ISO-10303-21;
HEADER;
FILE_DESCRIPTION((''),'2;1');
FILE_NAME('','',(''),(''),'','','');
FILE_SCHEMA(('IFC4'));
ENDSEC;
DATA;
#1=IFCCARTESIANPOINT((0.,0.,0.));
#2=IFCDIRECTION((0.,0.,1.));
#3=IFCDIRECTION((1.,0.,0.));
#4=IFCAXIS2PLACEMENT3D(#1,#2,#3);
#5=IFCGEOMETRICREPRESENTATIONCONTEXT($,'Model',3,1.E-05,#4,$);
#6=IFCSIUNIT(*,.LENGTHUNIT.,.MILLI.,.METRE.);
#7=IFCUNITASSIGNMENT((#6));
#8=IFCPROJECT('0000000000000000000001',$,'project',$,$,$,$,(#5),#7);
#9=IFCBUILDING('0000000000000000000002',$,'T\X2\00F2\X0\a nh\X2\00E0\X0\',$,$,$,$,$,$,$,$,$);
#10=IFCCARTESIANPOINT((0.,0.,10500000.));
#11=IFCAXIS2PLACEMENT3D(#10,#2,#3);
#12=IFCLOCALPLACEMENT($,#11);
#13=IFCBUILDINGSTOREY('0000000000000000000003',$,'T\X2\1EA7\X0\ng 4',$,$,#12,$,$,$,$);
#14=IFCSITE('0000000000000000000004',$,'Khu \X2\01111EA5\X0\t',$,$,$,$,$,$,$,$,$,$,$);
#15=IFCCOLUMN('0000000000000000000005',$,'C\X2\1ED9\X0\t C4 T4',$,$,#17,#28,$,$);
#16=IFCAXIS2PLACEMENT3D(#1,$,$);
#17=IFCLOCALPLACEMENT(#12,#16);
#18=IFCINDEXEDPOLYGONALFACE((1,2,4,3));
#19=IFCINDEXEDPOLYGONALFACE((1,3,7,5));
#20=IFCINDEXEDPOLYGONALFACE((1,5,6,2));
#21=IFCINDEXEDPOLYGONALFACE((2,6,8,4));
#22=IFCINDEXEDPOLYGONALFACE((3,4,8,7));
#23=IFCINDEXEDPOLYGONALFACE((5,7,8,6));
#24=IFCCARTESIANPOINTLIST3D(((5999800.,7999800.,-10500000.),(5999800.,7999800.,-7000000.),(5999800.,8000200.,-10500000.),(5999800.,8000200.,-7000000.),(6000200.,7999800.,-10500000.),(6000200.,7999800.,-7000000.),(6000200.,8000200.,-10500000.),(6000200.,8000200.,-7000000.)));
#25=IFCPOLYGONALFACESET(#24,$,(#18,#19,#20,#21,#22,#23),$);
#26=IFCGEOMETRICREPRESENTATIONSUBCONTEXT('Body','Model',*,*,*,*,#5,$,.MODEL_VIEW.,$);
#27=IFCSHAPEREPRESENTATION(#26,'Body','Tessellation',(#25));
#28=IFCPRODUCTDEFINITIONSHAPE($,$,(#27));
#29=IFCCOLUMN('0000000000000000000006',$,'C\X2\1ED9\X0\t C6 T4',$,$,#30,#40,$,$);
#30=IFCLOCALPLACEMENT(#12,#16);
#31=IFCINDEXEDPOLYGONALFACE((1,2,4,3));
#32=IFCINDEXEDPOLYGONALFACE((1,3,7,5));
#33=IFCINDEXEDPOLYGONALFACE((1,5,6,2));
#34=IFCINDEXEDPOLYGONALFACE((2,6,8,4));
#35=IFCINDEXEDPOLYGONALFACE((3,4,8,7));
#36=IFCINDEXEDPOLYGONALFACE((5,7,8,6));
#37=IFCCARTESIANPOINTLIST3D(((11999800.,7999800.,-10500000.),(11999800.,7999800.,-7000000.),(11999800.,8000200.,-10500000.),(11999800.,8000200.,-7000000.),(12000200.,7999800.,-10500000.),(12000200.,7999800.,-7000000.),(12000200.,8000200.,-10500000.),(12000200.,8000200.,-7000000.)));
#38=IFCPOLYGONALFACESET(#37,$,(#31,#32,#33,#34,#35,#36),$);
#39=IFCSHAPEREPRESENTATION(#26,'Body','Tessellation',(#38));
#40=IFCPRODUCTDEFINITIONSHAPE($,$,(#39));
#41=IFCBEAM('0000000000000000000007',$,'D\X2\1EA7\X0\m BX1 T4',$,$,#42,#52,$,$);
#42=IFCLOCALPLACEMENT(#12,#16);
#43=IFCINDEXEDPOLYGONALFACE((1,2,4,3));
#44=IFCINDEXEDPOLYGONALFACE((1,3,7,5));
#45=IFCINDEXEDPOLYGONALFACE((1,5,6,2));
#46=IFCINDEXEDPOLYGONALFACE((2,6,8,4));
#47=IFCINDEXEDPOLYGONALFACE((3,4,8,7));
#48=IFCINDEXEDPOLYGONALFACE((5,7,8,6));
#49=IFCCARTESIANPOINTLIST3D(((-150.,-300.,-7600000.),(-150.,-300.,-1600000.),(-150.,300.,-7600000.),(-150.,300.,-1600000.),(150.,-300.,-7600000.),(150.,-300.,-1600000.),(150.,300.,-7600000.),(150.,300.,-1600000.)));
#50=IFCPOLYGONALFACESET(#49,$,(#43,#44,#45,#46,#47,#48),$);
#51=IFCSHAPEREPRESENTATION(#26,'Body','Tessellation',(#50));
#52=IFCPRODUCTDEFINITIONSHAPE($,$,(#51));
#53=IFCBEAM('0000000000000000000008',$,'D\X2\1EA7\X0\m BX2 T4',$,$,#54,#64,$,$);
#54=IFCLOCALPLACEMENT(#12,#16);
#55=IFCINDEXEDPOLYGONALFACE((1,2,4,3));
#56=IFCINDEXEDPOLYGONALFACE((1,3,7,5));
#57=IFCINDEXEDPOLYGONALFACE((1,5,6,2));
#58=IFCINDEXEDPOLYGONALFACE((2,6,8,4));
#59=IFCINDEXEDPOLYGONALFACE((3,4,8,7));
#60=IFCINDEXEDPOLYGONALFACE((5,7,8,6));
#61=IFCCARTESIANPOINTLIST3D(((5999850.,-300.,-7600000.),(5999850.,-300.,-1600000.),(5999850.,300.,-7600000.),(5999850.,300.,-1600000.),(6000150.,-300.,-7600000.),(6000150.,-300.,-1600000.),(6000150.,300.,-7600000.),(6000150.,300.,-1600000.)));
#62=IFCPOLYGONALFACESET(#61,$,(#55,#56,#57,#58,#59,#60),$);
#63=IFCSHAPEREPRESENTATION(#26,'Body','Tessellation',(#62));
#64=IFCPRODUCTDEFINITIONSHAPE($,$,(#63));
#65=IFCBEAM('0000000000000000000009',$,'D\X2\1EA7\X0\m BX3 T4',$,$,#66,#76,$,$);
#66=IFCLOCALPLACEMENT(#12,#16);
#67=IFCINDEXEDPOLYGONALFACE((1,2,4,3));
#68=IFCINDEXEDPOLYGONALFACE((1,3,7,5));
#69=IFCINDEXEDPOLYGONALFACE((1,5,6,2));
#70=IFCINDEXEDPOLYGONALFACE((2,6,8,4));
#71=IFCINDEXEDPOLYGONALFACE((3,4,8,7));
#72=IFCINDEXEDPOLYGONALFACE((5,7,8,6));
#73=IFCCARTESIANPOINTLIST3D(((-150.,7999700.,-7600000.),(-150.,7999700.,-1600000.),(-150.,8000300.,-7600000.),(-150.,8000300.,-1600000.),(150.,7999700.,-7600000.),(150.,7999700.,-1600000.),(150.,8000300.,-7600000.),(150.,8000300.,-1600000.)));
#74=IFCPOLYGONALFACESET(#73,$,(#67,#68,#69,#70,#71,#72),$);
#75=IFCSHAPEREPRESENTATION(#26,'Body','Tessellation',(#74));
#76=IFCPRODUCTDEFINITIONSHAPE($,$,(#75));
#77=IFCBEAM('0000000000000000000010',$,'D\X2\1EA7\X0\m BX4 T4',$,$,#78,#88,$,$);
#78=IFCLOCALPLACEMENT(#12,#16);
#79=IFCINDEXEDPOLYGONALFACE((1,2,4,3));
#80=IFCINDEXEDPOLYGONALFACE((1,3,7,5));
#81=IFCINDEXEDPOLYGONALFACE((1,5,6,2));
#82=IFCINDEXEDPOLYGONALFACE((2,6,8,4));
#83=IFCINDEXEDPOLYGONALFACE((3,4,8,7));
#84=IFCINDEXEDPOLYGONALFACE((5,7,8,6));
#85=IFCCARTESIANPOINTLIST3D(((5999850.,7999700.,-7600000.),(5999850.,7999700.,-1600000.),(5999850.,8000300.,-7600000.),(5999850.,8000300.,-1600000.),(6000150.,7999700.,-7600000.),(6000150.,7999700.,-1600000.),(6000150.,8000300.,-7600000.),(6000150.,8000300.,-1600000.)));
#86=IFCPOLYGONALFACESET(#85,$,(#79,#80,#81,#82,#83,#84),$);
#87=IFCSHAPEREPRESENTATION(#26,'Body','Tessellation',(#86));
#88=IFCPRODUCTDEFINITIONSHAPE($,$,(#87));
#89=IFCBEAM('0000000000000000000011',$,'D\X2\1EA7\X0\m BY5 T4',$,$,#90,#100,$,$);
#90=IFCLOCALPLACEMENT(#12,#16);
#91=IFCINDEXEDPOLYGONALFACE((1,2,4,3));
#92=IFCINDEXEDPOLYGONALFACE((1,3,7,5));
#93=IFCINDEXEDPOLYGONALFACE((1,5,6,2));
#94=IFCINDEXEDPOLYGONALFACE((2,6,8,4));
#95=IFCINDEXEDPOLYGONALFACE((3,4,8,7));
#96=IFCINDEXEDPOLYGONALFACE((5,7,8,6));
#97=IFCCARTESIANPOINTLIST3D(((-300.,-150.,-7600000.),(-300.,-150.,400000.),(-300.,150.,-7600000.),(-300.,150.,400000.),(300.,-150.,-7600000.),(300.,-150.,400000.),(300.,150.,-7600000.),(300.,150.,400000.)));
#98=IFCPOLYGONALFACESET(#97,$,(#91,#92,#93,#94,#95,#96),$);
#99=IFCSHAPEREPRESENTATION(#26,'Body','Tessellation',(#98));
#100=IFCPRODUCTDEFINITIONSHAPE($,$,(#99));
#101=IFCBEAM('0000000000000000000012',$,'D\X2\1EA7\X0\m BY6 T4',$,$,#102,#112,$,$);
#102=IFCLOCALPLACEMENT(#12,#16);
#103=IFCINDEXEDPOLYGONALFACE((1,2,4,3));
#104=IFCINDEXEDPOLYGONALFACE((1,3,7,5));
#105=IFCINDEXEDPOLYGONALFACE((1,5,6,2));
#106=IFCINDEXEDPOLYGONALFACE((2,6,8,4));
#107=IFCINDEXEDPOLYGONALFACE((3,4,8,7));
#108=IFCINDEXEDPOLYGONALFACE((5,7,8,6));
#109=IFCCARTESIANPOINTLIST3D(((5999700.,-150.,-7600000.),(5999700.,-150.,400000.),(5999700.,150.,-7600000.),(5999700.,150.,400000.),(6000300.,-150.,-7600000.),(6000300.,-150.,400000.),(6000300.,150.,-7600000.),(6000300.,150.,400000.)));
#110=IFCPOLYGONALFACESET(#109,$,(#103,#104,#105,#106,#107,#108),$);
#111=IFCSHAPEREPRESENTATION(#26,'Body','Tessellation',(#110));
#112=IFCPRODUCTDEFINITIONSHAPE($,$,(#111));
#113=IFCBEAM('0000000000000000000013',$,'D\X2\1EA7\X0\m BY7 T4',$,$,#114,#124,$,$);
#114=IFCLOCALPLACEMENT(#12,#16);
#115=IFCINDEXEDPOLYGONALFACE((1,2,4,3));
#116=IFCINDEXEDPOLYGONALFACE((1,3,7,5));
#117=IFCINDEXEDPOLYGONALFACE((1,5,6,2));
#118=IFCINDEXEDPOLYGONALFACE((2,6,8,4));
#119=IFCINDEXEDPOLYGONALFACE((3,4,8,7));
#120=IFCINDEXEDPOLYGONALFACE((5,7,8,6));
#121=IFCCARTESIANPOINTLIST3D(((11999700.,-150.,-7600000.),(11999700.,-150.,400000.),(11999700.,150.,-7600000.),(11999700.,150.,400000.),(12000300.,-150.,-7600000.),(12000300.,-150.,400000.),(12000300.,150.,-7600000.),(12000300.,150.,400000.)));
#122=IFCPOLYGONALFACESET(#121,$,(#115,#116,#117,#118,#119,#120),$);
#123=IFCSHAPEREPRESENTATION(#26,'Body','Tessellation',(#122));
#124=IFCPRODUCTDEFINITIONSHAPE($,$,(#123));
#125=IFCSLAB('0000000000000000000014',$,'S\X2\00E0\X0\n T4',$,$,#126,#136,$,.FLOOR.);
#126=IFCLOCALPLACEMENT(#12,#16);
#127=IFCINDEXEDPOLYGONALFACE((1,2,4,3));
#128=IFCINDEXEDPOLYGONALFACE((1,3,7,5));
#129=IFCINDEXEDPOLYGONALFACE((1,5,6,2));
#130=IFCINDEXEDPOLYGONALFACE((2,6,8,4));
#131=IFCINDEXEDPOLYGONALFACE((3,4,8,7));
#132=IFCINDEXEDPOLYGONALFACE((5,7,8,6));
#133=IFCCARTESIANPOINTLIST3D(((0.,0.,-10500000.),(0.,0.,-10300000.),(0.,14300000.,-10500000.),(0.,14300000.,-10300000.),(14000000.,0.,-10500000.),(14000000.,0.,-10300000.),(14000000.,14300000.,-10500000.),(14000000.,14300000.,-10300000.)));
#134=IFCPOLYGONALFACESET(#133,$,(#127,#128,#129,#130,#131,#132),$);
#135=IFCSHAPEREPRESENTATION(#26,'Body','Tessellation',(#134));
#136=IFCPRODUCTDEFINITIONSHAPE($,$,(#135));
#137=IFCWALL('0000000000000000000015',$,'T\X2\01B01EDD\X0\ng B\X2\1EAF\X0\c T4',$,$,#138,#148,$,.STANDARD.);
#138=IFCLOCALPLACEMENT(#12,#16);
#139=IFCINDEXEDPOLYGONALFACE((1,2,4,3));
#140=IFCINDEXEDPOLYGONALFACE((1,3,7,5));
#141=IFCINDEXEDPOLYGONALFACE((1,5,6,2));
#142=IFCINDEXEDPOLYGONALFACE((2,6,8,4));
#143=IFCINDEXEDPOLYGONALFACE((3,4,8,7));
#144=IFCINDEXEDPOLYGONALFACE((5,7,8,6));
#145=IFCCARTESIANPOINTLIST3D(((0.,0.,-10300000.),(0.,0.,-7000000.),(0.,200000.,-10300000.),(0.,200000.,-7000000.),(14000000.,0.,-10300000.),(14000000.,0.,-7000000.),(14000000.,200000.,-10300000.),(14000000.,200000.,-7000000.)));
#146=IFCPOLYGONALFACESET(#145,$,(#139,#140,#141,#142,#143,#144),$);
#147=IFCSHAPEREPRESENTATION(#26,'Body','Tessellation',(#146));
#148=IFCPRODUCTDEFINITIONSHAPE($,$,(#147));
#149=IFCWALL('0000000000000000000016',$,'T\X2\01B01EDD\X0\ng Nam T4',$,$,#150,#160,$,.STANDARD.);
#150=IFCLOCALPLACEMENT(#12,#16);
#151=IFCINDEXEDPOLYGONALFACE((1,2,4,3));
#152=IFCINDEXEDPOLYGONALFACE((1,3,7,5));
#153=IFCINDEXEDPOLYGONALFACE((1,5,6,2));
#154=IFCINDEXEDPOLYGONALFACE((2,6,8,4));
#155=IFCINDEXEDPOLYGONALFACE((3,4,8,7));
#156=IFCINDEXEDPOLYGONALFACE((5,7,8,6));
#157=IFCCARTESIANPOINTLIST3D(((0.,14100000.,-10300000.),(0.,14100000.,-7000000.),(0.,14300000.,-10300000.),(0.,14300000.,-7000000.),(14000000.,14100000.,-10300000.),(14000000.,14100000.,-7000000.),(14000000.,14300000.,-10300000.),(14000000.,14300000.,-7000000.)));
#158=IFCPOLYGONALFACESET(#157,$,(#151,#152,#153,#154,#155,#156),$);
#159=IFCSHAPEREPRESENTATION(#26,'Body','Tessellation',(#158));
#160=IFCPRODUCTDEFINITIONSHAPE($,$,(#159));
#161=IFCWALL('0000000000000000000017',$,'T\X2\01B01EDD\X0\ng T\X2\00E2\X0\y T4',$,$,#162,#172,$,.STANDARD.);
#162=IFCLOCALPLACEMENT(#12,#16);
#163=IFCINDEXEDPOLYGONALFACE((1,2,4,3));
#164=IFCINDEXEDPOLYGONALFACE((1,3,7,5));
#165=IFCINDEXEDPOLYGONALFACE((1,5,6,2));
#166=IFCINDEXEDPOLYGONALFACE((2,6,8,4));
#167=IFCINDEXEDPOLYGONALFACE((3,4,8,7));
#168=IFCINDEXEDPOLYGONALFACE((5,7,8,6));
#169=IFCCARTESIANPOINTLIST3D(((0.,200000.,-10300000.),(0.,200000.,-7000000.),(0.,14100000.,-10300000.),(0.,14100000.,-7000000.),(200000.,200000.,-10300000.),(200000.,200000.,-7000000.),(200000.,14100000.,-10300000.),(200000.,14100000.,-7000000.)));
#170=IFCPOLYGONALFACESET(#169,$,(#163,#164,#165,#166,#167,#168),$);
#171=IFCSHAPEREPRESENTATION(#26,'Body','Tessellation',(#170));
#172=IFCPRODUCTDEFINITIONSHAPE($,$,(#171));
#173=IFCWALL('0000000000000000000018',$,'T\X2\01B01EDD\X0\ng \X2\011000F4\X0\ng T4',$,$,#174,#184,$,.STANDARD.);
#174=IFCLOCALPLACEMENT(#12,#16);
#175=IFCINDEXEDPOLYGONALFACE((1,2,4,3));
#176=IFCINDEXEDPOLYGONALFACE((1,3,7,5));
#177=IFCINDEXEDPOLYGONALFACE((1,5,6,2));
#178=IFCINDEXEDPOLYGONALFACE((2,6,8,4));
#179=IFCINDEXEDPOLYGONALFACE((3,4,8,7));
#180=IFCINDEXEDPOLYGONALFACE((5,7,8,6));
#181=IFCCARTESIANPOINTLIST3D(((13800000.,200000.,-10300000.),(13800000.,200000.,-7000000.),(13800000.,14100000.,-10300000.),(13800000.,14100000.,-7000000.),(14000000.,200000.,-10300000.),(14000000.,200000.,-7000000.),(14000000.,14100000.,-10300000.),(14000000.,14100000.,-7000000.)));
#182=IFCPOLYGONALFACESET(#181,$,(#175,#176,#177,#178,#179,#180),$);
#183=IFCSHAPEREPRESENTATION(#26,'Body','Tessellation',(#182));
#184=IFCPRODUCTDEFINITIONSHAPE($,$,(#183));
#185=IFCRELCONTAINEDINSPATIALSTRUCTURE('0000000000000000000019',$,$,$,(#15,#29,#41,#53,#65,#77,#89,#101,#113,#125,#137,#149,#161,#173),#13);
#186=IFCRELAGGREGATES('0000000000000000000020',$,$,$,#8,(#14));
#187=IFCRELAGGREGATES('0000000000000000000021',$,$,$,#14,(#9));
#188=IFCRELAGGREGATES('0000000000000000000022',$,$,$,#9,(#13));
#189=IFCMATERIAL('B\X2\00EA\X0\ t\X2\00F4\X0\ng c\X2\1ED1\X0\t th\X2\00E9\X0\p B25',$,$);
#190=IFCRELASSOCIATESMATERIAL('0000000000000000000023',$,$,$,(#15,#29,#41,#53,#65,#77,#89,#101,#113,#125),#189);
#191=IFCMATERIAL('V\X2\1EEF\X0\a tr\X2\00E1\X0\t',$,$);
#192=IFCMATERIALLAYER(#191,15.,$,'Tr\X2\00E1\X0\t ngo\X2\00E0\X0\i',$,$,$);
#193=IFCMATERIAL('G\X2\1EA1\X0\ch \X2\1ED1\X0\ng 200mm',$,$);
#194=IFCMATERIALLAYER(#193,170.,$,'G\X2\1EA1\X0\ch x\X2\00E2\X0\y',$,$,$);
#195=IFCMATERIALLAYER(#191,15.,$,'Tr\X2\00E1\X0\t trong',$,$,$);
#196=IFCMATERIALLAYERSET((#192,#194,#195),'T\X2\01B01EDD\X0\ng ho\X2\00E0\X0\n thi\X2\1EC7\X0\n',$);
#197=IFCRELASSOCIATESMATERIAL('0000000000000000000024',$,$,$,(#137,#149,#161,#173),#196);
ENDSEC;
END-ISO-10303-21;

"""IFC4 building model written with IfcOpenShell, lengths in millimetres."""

from ifc_helpers import new_model, entity, si_unit, frame, origin_with_axes, place, context, subcontext, project, spatial, indexed_curve, outline, extrude, material, layer, layer_set, layer_usage, element, save


model = new_model("IFC4")

# Units and contexts
model_context = context("Model", 3, precision=1e-05, world=origin_with_axes())
body_context = subcontext(model_context, "Body", "Model", "MODEL_VIEW")
ifc_project = project(units=[si_unit("LENGTHUNIT", "METRE", prefix="MILLI")], contexts=[model_context])

# Site, building, storey
site = spatial("IfcSite", under=ifc_project, Name="Khu đất")
building = spatial("IfcBuilding", under=site, Name="Tòa nhà")
storey_placement = place(None, frame((0.0, 0.0, 10500000.0), z_axis=(0.0, 0.0, 1.0), x_axis=(1.0, 0.0, 0.0)))
storey = spatial("IfcBuildingStorey", under=building, at=storey_placement, Name="Tầng 4")

# Columns
ifc_material_1 = material(Name="Bê tông cốt thép B25")
for number, where, z_axis, x_axis, name in (
    (1, (6000000.0, 8000000.0, -10500000.0), (0.0, 0.0, 1.0), (1.0, 0.0, 0.0), "Cột C4 T4"),
    (2, (12000000.0, 8000000.0, -10500000.0), (0.0, 0.0, 1.0), (1.0, 0.0, 0.0), "Cột C6 T4"),
):
    element("IfcColumn", number, at=place(storey_placement, frame(where, z_axis=z_axis, x_axis=x_axis)), inside=storey, material=ifc_material_1, Name=name, context=body_context, shape_type="SweptSolid", body=[
        extrude(entity("IfcRectangleProfileDef", None, None, None, 400.0, 400.0), origin_with_axes(), (0.0, 0.0, 1.0), 3500000.0),
    ])

# Beams
for number, where, z_axis, x_axis, name in (
    (3, (0.0, 0.0, -7600000.0), (0.0, 0.0, 1.0), (1.0, 0.0, 0.0), "Dầm BX1 T4"),
    (4, (6000000.0, 0.0, -7600000.0), (0.0, 0.0, 1.0), (1.0, 0.0, 0.0), "Dầm BX2 T4"),
    (5, (0.0, 8000000.0, -7600000.0), (0.0, 0.0, 1.0), (1.0, 0.0, 0.0), "Dầm BX3 T4"),
    (6, (6000000.0, 8000000.0, -7600000.0), (0.0, 0.0, 1.0), (1.0, 0.0, 0.0), "Dầm BX4 T4"),
):
    element("IfcBeam", number, at=place(storey_placement, frame(where, z_axis=z_axis, x_axis=x_axis)), inside=storey, material=ifc_material_1, Name=name, context=body_context, shape_type="SweptSolid", body=[
        extrude(entity("IfcRectangleProfileDef", None, None, None, 300.0, 600.0), origin_with_axes(), (0.0, 0.0, 1.0), 6000000.0),
    ])
for number, where, z_axis, x_axis, name in (
    (7, (0.0, 0.0, -7600000.0), (0.0, 0.0, 1.0), (0.0, 1.0, 0.0), "Dầm BY5 T4"),
    (8, (6000000.0, 0.0, -7600000.0), (0.0, 0.0, 1.0), (0.0, 1.0, 0.0), "Dầm BY6 T4"),
    (9, (12000000.0, 0.0, -7600000.0), (0.0, 0.0, 1.0), (0.0, 1.0, 0.0), "Dầm BY7 T4"),
):
    element("IfcBeam", number, at=place(storey_placement, frame(where, z_axis=z_axis, x_axis=x_axis)), inside=storey, material=ifc_material_1, Name=name, context=body_context, shape_type="SweptSolid", body=[
        extrude(entity("IfcRectangleProfileDef", None, None, None, 300.0, 600.0), origin_with_axes(), (0.0, 0.0, 1.0), 8000000.0),
    ])

# Slab
slab_placement = place(storey_placement, frame((0.0, 0.0, -10500000.0), z_axis=(0.0, 0.0, 1.0), x_axis=(1.0, 0.0, 0.0)))
element("IfcSlab", 10, at=slab_placement, inside=storey, material=ifc_material_1, Name="Sàn T4", PredefinedType="FLOOR", context=body_context, shape_type="SweptSolid", body=[
    extrude(outline(indexed_curve([(0.0, 0.0), (14000000.0, 0.0), (14000000.0, 14300000.0), (0.0, 14300000.0), (0.0, 0.0)])), None, (0.0, 0.0, 1.0), 200000.0),
])

# Walls
ifc_material_2 = material(Name="Vữa trát")
ifc_layer_1 = layer(ifc_material_2, 15.0, Name="Trát ngoài")
ifc_material_3 = material(Name="Gạch ống 200mm")
ifc_layer_2 = layer(ifc_material_3, 170.0, Name="Gạch xây")
ifc_layer_3 = layer(ifc_material_2, 15.0, Name="Trát trong")
ifc_layer_set = layer_set([ifc_layer_1, ifc_layer_2, ifc_layer_3], Name="Tường hoàn thiện")
ifc_layer_usage_1 = layer_usage(ifc_layer_set, "AXIS2", "POSITIVE", 0.0)
wall_1_placement = place(storey_placement, frame((0.0, 0.0, -10300000.0), z_axis=(0.0, 0.0, 1.0), x_axis=(1.0, 0.0, 0.0)))
element("IfcWall", 11, at=wall_1_placement, inside=storey, material=ifc_layer_usage_1, Name="Tường Bắc T4", PredefinedType="STANDARD", context=body_context, shape_type="SweptSolid", body=[
    extrude(outline(indexed_curve([(0.0, 0.0), (0.0, 200000.0), (14000000.0, 200000.0), (14000000.0, 0.0), (0.0, 0.0)], self_intersect=False)), origin_with_axes(), (0.0, 0.0, 1.0), 3300000.0),
])
ifc_layer_usage_2 = layer_usage(ifc_layer_set, "AXIS2", "POSITIVE", 0.0)
wall_2_placement = place(storey_placement, frame((0.0, 14100000.0, -10300000.0), z_axis=(0.0, 0.0, 1.0), x_axis=(1.0, 0.0, 0.0)))
element("IfcWall", 12, at=wall_2_placement, inside=storey, material=ifc_layer_usage_2, Name="Tường Nam T4", PredefinedType="STANDARD", context=body_context, shape_type="SweptSolid", body=[
    extrude(outline(indexed_curve([(0.0, 0.0), (0.0, 200000.0), (14000000.0, 200000.0), (14000000.0, 0.0), (0.0, 0.0)], self_intersect=False)), origin_with_axes(), (0.0, 0.0, 1.0), 3300000.0),
])
ifc_layer_usage_3 = layer_usage(ifc_layer_set, "AXIS2", "POSITIVE", 0.0)
wall_3_placement = place(storey_placement, frame((0.0, 200000.0, -10300000.0), z_axis=(0.0, 0.0, 1.0), x_axis=(1.0, 0.0, 0.0)))
element("IfcWall", 13, at=wall_3_placement, inside=storey, material=ifc_layer_usage_3, Name="Tường Tây T4", PredefinedType="STANDARD", context=body_context, shape_type="SweptSolid", body=[
    extrude(outline(indexed_curve([(0.0, 0.0), (0.0, 13900000.0), (200000.0, 13900000.0), (200000.0, 0.0), (0.0, 0.0)], self_intersect=False)), origin_with_axes(), (0.0, 0.0, 1.0), 3300000.0),
])
ifc_layer_usage_4 = layer_usage(ifc_layer_set, "AXIS2", "POSITIVE", 0.0)
wall_4_placement = place(storey_placement, frame((13800000.0, 200000.0, -10300000.0), z_axis=(0.0, 0.0, 1.0), x_axis=(1.0, 0.0, 0.0)))
element("IfcWall", 14, at=wall_4_placement, inside=storey, material=ifc_layer_usage_4, Name="Tường Đông T4", PredefinedType="STANDARD", context=body_context, shape_type="SweptSolid", body=[
    extrude(outline(indexed_curve([(0.0, 0.0), (0.0, 13900000.0), (200000.0, 13900000.0), (200000.0, 0.0), (0.0, 0.0)], self_intersect=False)), origin_with_axes(), (0.0, 0.0, 1.0), 3300000.0),
])

save(model, "model.ifc")
